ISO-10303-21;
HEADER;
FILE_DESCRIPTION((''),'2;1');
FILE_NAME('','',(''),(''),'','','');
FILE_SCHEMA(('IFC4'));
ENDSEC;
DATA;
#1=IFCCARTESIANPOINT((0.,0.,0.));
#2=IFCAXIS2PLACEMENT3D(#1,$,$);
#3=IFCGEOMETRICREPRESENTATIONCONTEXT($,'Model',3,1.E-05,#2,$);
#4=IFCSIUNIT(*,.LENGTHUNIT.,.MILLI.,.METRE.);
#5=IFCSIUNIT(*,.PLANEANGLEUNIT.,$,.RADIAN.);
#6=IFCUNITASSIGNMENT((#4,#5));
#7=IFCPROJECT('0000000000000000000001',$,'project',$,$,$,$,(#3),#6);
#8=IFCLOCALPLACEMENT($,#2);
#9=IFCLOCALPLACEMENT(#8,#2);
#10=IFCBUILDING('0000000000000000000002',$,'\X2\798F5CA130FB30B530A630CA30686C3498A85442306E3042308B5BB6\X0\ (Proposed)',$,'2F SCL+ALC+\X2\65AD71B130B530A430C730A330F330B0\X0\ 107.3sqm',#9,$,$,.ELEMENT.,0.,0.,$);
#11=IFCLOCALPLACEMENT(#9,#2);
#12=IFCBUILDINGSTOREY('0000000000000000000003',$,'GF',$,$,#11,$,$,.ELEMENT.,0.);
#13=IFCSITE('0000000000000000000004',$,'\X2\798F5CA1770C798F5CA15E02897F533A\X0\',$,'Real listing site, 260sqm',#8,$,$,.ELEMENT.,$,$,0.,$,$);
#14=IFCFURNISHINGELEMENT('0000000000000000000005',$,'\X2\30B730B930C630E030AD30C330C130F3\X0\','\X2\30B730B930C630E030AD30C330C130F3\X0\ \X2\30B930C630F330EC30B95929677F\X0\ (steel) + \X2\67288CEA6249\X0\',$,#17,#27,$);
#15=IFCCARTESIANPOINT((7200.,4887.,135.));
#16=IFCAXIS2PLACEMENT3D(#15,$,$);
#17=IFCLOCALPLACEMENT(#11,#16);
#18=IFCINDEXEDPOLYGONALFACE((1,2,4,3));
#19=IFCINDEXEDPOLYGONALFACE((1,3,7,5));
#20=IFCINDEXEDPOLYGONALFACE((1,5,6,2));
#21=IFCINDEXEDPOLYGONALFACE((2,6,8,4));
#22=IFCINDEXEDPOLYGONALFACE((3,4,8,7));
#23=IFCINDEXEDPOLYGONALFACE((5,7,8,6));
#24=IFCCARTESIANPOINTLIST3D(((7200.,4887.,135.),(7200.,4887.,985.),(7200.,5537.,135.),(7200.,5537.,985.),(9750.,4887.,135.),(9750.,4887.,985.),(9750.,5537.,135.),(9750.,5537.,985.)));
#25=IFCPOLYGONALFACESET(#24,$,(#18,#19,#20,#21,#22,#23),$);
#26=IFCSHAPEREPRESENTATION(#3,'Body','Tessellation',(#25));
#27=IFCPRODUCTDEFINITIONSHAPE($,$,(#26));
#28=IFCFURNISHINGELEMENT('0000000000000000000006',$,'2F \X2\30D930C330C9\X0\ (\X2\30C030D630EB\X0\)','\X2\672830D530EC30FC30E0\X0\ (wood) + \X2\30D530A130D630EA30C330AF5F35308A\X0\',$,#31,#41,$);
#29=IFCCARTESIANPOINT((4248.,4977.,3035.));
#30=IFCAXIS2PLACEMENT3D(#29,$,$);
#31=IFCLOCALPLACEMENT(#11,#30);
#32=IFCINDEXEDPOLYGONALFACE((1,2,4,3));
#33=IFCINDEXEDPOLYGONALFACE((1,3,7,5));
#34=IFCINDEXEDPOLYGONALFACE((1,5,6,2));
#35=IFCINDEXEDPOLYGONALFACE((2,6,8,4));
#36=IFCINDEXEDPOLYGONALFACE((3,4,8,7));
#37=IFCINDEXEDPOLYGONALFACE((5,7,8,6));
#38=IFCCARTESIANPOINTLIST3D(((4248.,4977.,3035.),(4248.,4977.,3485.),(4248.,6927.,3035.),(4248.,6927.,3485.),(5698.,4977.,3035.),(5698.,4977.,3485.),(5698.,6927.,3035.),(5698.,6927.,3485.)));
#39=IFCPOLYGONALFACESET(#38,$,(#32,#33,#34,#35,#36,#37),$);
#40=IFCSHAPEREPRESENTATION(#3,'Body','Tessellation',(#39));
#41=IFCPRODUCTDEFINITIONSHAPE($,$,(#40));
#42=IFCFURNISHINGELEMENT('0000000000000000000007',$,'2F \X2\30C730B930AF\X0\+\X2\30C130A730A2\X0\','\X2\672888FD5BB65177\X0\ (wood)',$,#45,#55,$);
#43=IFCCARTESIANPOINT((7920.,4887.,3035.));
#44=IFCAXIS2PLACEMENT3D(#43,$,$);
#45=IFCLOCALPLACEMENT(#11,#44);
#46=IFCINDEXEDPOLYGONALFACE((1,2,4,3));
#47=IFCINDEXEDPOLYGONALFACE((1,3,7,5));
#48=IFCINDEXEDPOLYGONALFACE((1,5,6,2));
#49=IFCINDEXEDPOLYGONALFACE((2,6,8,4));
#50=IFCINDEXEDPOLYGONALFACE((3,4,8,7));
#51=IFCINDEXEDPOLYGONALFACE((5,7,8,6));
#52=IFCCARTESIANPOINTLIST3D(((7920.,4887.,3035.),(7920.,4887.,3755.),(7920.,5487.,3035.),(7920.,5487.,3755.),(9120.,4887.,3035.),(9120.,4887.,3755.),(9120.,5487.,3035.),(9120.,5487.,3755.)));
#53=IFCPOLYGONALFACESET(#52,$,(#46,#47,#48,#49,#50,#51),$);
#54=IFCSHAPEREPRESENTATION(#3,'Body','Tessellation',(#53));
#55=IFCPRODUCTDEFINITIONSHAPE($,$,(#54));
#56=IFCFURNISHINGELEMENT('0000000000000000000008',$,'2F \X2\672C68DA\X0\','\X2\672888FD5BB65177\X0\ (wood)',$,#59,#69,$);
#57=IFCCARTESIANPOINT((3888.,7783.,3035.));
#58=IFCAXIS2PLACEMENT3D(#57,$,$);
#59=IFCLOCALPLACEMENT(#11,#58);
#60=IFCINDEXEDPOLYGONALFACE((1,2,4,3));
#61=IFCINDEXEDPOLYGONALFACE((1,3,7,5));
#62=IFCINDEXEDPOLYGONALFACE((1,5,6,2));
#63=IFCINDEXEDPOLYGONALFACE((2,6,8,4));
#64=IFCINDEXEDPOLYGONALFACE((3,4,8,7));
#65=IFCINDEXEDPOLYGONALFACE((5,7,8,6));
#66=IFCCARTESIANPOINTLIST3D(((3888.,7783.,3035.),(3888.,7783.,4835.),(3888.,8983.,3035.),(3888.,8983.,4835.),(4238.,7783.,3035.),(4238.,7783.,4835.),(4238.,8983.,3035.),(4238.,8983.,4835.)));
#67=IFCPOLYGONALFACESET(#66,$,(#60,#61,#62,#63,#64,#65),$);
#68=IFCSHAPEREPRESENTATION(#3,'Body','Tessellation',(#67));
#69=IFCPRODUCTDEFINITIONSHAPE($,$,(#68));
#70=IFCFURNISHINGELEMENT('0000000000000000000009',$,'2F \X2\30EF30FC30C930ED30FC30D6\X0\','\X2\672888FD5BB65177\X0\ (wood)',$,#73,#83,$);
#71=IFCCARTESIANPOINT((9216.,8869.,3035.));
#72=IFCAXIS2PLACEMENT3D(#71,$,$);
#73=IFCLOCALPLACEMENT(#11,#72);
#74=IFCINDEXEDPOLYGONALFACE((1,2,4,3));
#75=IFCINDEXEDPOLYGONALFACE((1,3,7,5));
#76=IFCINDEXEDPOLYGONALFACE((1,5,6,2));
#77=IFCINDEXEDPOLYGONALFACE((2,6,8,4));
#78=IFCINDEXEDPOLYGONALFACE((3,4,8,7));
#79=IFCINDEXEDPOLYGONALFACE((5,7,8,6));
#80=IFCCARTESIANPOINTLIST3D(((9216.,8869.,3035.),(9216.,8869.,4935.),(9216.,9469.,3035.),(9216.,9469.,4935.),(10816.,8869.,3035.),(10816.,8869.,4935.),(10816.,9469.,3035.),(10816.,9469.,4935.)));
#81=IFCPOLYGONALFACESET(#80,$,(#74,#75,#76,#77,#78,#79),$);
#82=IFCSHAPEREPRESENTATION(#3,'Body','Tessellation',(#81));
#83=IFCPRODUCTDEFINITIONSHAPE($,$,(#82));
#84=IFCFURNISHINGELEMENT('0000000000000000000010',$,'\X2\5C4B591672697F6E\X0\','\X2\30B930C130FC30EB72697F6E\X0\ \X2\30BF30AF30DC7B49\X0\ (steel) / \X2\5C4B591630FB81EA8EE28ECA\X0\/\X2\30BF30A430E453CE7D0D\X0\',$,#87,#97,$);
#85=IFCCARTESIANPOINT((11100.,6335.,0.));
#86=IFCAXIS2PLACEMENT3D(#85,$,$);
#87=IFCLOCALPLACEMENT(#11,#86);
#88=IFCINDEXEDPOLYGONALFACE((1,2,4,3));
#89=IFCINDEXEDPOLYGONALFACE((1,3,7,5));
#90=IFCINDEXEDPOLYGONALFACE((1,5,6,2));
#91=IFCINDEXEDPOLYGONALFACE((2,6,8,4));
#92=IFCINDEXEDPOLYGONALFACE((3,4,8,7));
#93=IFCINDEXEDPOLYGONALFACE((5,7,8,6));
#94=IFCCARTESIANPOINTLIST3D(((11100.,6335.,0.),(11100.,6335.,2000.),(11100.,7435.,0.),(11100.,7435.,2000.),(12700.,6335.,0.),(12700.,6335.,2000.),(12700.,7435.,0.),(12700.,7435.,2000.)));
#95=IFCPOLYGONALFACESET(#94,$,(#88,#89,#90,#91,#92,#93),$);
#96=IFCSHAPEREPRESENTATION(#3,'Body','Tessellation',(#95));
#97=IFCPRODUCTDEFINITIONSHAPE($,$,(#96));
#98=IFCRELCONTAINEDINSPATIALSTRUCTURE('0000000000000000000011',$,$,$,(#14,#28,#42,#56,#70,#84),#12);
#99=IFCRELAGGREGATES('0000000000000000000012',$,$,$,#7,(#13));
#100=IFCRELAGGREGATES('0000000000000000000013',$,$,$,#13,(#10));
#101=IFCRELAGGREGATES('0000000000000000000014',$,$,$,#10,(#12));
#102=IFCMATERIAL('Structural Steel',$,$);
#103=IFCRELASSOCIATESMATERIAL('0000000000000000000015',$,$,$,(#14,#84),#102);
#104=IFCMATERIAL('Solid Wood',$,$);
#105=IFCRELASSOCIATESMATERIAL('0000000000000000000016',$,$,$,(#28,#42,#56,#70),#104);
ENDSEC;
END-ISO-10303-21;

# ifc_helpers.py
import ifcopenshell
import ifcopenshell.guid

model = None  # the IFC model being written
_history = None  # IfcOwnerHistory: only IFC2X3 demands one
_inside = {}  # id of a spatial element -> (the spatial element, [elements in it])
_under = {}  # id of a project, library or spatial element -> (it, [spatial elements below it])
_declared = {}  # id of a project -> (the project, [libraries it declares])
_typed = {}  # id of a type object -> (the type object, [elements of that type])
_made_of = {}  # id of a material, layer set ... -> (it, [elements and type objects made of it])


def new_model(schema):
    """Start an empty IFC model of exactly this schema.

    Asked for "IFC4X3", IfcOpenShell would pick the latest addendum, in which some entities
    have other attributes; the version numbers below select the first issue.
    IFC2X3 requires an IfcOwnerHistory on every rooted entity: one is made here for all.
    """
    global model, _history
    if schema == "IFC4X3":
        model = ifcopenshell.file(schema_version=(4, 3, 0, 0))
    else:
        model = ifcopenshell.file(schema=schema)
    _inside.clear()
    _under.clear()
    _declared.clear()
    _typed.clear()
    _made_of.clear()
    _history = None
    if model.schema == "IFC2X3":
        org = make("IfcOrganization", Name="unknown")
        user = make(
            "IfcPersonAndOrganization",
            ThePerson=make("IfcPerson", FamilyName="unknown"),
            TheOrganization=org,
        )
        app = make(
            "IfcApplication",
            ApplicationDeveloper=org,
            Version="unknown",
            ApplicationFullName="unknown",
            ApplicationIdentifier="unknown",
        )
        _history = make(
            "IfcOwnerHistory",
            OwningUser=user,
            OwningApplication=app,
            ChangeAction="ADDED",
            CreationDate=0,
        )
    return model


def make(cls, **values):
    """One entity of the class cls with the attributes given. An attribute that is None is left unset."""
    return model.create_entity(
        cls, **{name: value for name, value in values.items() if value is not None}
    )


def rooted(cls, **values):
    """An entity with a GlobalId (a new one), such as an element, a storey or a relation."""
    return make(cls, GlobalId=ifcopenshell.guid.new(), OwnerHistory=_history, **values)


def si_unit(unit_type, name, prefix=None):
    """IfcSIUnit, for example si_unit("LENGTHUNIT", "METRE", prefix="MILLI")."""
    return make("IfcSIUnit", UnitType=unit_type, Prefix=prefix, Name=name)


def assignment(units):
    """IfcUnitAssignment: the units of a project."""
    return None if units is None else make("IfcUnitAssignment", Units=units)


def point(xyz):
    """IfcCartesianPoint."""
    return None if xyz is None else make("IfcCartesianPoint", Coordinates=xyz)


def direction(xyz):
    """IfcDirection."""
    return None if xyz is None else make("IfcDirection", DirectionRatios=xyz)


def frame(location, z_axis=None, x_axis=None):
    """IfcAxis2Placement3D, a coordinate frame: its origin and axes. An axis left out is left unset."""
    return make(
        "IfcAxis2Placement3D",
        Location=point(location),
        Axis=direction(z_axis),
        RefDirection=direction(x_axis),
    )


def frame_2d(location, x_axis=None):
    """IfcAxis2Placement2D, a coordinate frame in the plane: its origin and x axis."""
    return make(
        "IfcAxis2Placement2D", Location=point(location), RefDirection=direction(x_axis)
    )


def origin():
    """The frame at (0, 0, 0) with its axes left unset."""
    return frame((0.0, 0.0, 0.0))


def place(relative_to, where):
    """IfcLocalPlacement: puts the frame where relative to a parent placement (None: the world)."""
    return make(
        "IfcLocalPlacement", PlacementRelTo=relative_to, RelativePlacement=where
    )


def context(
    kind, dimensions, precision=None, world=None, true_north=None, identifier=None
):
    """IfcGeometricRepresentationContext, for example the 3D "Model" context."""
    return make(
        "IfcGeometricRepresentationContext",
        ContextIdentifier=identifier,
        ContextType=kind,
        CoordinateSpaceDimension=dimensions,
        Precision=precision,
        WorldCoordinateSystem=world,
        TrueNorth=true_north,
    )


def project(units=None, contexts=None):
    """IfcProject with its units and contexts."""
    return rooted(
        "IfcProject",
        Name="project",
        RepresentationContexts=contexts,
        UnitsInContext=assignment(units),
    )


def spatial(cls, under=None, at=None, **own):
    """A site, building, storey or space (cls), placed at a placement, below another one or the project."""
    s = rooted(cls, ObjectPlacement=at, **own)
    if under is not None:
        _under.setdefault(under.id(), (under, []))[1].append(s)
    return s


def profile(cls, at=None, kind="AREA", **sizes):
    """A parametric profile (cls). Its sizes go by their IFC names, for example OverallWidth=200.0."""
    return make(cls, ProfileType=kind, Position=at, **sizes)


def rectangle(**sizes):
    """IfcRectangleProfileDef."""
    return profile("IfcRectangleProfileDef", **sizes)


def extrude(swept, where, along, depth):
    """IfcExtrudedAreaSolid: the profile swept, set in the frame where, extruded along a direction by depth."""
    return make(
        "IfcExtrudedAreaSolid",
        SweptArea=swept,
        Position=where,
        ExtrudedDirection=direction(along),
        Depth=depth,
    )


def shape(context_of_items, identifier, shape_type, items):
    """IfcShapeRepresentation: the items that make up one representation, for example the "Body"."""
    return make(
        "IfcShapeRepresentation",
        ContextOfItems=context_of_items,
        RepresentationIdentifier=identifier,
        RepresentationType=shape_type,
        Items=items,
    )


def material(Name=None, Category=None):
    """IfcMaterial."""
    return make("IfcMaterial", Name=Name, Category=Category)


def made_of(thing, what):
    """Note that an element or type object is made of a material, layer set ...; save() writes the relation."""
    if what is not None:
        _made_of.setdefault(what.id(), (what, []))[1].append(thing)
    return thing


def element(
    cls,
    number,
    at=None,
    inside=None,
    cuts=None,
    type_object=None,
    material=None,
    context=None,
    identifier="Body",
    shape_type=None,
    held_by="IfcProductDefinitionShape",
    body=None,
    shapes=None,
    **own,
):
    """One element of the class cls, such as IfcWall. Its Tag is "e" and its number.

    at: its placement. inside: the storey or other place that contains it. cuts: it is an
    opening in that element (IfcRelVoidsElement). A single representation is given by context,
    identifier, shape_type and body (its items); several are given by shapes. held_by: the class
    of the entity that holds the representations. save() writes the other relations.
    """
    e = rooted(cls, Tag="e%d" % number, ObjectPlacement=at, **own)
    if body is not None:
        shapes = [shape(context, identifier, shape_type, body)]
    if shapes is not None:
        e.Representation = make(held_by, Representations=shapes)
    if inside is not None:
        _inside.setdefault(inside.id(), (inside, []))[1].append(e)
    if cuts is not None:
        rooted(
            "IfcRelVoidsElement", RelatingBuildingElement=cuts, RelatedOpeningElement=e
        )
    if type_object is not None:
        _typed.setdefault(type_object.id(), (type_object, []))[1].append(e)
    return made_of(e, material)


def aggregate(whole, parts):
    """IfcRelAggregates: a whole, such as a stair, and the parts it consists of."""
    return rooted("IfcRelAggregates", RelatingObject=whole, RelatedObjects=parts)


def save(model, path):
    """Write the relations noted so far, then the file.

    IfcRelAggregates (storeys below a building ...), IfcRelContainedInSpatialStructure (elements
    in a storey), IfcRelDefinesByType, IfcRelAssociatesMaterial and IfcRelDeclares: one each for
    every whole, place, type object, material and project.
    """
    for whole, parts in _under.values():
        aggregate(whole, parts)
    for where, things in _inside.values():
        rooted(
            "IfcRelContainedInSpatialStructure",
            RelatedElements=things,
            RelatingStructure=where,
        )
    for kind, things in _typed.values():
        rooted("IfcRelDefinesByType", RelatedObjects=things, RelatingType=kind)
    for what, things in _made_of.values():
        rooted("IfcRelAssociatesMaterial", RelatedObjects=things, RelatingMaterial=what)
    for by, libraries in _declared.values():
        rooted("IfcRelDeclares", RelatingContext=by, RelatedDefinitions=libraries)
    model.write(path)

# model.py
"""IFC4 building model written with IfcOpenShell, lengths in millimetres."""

from ifc_helpers import new_model, si_unit, frame, frame_2d, origin, place, context, project, spatial, rectangle, extrude, material, element, save


model = new_model("IFC4")

# Units and contexts
model_context = context("Model", 3, precision=1e-05, world=origin())
ifc_project = project(units=[si_unit("LENGTHUNIT", "METRE", prefix="MILLI"), si_unit("PLANEANGLEUNIT", "RADIAN")], contexts=[model_context])

# Site, building, storey
site_placement = place(None, origin())
site = spatial("IfcSite", under=ifc_project, at=site_placement, Name="福岡県福岡市西区", ObjectType="Real listing site, 260sqm", CompositionType="ELEMENT", RefElevation=0.0)
building_placement = place(site_placement, origin())
building = spatial("IfcBuilding", under=site, at=building_placement, Name="福岡・サウナと水風呂のある家 (Proposed)", ObjectType="2F SCL+ALC+断熱サイディング 107.3sqm", CompositionType="ELEMENT", ElevationOfRefHeight=0.0, ElevationOfTerrain=0.0)
storey_placement = place(building_placement, origin())
storey = spatial("IfcBuildingStorey", under=building, at=storey_placement, Name="GF", CompositionType="ELEMENT", Elevation=0.0)

# Shared definitions
ifc_material_1 = material(Name="Solid Wood")

# Shared definitions
ifc_material_2 = material(Name="Structural Steel")

# Furnishing elements
furnishing_1_placement = place(storey_placement, frame((7200.0, 4887.0, 135.0)))
element("IfcFurnishingElement", 1, at=furnishing_1_placement, inside=storey, material=ifc_material_2, Name="システムキッチン", Description="システムキッチン ステンレス天板 (steel) + 木質扉", context=model_context, shape_type="SweptSolid", body=[
    extrude(rectangle(XDim=2550.0, YDim=650.0, at=frame_2d((1275.0, 325.0))), frame((7200.0, 4887.0, 135.0)), (0.0, 0.0, 1.0), 850.0),
])
furnishing_2_placement = place(storey_placement, frame((4248.0, 4977.0, 3035.0)))
element("IfcFurnishingElement", 2, at=furnishing_2_placement, inside=storey, material=ifc_material_1, Name="2F ベッド (ダブル)", Description="木フレーム (wood) + ファブリック張り", context=model_context, shape_type="SweptSolid", body=[
    extrude(rectangle(XDim=1450.0, YDim=1950.0, at=frame_2d((725.0, 975.0))), frame((4248.0, 4977.0, 3035.0)), (0.0, 0.0, 1.0), 450.0),
])
furnishing_3_placement = place(storey_placement, frame((7920.0, 4887.0, 3035.0)))
element("IfcFurnishingElement", 3, at=furnishing_3_placement, inside=storey, material=ifc_material_1, Name="2F デスク+チェア", Description="木製家具 (wood)", context=model_context, shape_type="SweptSolid", body=[
    extrude(rectangle(XDim=1200.0, YDim=600.0, at=frame_2d((600.0, 300.0))), frame((7920.0, 4887.0, 3035.0)), (0.0, 0.0, 1.0), 720.0),
])
furnishing_4_placement = place(storey_placement, frame((3888.0, 7783.0, 3035.0)))
element("IfcFurnishingElement", 4, at=furnishing_4_placement, inside=storey, material=ifc_material_1, Name="2F 本棚", Description="木製家具 (wood)", context=model_context, shape_type="SweptSolid", body=[
    extrude(rectangle(XDim=350.0, YDim=1200.0, at=frame_2d((175.0, 600.0))), frame((3888.0, 7783.0, 3035.0)), (0.0, 0.0, 1.0), 1800.0),
])
furnishing_5_placement = place(storey_placement, frame((9216.0, 8869.0, 3035.0)))
element("IfcFurnishingElement", 5, at=furnishing_5_placement, inside=storey, material=ifc_material_1, Name="2F ワードローブ", Description="木製家具 (wood)", context=model_context, shape_type="SweptSolid", body=[
    extrude(rectangle(XDim=1600.0, YDim=600.0, at=frame_2d((800.0, 300.0))), frame((9216.0, 8869.0, 3035.0)), (0.0, 0.0, 1.0), 1900.0),
])
furnishing_6_placement = place(storey_placement, frame((11100.0, 6335.0, 0.0)))
element("IfcFurnishingElement", 6, at=furnishing_6_placement, inside=storey, material=ifc_material_2, Name="屋外物置", Description="スチール物置 タクボ等 (steel) / 屋外・自転車/タイヤ収納", context=model_context, shape_type="SweptSolid", body=[
    extrude(rectangle(XDim=1600.0, YDim=1100.0, at=frame_2d((800.0, 550.0))), frame((11100.0, 6335.0, 0.0)), (0.0, 0.0, 1.0), 2000.0),
])

save(model, "model.ifc")
